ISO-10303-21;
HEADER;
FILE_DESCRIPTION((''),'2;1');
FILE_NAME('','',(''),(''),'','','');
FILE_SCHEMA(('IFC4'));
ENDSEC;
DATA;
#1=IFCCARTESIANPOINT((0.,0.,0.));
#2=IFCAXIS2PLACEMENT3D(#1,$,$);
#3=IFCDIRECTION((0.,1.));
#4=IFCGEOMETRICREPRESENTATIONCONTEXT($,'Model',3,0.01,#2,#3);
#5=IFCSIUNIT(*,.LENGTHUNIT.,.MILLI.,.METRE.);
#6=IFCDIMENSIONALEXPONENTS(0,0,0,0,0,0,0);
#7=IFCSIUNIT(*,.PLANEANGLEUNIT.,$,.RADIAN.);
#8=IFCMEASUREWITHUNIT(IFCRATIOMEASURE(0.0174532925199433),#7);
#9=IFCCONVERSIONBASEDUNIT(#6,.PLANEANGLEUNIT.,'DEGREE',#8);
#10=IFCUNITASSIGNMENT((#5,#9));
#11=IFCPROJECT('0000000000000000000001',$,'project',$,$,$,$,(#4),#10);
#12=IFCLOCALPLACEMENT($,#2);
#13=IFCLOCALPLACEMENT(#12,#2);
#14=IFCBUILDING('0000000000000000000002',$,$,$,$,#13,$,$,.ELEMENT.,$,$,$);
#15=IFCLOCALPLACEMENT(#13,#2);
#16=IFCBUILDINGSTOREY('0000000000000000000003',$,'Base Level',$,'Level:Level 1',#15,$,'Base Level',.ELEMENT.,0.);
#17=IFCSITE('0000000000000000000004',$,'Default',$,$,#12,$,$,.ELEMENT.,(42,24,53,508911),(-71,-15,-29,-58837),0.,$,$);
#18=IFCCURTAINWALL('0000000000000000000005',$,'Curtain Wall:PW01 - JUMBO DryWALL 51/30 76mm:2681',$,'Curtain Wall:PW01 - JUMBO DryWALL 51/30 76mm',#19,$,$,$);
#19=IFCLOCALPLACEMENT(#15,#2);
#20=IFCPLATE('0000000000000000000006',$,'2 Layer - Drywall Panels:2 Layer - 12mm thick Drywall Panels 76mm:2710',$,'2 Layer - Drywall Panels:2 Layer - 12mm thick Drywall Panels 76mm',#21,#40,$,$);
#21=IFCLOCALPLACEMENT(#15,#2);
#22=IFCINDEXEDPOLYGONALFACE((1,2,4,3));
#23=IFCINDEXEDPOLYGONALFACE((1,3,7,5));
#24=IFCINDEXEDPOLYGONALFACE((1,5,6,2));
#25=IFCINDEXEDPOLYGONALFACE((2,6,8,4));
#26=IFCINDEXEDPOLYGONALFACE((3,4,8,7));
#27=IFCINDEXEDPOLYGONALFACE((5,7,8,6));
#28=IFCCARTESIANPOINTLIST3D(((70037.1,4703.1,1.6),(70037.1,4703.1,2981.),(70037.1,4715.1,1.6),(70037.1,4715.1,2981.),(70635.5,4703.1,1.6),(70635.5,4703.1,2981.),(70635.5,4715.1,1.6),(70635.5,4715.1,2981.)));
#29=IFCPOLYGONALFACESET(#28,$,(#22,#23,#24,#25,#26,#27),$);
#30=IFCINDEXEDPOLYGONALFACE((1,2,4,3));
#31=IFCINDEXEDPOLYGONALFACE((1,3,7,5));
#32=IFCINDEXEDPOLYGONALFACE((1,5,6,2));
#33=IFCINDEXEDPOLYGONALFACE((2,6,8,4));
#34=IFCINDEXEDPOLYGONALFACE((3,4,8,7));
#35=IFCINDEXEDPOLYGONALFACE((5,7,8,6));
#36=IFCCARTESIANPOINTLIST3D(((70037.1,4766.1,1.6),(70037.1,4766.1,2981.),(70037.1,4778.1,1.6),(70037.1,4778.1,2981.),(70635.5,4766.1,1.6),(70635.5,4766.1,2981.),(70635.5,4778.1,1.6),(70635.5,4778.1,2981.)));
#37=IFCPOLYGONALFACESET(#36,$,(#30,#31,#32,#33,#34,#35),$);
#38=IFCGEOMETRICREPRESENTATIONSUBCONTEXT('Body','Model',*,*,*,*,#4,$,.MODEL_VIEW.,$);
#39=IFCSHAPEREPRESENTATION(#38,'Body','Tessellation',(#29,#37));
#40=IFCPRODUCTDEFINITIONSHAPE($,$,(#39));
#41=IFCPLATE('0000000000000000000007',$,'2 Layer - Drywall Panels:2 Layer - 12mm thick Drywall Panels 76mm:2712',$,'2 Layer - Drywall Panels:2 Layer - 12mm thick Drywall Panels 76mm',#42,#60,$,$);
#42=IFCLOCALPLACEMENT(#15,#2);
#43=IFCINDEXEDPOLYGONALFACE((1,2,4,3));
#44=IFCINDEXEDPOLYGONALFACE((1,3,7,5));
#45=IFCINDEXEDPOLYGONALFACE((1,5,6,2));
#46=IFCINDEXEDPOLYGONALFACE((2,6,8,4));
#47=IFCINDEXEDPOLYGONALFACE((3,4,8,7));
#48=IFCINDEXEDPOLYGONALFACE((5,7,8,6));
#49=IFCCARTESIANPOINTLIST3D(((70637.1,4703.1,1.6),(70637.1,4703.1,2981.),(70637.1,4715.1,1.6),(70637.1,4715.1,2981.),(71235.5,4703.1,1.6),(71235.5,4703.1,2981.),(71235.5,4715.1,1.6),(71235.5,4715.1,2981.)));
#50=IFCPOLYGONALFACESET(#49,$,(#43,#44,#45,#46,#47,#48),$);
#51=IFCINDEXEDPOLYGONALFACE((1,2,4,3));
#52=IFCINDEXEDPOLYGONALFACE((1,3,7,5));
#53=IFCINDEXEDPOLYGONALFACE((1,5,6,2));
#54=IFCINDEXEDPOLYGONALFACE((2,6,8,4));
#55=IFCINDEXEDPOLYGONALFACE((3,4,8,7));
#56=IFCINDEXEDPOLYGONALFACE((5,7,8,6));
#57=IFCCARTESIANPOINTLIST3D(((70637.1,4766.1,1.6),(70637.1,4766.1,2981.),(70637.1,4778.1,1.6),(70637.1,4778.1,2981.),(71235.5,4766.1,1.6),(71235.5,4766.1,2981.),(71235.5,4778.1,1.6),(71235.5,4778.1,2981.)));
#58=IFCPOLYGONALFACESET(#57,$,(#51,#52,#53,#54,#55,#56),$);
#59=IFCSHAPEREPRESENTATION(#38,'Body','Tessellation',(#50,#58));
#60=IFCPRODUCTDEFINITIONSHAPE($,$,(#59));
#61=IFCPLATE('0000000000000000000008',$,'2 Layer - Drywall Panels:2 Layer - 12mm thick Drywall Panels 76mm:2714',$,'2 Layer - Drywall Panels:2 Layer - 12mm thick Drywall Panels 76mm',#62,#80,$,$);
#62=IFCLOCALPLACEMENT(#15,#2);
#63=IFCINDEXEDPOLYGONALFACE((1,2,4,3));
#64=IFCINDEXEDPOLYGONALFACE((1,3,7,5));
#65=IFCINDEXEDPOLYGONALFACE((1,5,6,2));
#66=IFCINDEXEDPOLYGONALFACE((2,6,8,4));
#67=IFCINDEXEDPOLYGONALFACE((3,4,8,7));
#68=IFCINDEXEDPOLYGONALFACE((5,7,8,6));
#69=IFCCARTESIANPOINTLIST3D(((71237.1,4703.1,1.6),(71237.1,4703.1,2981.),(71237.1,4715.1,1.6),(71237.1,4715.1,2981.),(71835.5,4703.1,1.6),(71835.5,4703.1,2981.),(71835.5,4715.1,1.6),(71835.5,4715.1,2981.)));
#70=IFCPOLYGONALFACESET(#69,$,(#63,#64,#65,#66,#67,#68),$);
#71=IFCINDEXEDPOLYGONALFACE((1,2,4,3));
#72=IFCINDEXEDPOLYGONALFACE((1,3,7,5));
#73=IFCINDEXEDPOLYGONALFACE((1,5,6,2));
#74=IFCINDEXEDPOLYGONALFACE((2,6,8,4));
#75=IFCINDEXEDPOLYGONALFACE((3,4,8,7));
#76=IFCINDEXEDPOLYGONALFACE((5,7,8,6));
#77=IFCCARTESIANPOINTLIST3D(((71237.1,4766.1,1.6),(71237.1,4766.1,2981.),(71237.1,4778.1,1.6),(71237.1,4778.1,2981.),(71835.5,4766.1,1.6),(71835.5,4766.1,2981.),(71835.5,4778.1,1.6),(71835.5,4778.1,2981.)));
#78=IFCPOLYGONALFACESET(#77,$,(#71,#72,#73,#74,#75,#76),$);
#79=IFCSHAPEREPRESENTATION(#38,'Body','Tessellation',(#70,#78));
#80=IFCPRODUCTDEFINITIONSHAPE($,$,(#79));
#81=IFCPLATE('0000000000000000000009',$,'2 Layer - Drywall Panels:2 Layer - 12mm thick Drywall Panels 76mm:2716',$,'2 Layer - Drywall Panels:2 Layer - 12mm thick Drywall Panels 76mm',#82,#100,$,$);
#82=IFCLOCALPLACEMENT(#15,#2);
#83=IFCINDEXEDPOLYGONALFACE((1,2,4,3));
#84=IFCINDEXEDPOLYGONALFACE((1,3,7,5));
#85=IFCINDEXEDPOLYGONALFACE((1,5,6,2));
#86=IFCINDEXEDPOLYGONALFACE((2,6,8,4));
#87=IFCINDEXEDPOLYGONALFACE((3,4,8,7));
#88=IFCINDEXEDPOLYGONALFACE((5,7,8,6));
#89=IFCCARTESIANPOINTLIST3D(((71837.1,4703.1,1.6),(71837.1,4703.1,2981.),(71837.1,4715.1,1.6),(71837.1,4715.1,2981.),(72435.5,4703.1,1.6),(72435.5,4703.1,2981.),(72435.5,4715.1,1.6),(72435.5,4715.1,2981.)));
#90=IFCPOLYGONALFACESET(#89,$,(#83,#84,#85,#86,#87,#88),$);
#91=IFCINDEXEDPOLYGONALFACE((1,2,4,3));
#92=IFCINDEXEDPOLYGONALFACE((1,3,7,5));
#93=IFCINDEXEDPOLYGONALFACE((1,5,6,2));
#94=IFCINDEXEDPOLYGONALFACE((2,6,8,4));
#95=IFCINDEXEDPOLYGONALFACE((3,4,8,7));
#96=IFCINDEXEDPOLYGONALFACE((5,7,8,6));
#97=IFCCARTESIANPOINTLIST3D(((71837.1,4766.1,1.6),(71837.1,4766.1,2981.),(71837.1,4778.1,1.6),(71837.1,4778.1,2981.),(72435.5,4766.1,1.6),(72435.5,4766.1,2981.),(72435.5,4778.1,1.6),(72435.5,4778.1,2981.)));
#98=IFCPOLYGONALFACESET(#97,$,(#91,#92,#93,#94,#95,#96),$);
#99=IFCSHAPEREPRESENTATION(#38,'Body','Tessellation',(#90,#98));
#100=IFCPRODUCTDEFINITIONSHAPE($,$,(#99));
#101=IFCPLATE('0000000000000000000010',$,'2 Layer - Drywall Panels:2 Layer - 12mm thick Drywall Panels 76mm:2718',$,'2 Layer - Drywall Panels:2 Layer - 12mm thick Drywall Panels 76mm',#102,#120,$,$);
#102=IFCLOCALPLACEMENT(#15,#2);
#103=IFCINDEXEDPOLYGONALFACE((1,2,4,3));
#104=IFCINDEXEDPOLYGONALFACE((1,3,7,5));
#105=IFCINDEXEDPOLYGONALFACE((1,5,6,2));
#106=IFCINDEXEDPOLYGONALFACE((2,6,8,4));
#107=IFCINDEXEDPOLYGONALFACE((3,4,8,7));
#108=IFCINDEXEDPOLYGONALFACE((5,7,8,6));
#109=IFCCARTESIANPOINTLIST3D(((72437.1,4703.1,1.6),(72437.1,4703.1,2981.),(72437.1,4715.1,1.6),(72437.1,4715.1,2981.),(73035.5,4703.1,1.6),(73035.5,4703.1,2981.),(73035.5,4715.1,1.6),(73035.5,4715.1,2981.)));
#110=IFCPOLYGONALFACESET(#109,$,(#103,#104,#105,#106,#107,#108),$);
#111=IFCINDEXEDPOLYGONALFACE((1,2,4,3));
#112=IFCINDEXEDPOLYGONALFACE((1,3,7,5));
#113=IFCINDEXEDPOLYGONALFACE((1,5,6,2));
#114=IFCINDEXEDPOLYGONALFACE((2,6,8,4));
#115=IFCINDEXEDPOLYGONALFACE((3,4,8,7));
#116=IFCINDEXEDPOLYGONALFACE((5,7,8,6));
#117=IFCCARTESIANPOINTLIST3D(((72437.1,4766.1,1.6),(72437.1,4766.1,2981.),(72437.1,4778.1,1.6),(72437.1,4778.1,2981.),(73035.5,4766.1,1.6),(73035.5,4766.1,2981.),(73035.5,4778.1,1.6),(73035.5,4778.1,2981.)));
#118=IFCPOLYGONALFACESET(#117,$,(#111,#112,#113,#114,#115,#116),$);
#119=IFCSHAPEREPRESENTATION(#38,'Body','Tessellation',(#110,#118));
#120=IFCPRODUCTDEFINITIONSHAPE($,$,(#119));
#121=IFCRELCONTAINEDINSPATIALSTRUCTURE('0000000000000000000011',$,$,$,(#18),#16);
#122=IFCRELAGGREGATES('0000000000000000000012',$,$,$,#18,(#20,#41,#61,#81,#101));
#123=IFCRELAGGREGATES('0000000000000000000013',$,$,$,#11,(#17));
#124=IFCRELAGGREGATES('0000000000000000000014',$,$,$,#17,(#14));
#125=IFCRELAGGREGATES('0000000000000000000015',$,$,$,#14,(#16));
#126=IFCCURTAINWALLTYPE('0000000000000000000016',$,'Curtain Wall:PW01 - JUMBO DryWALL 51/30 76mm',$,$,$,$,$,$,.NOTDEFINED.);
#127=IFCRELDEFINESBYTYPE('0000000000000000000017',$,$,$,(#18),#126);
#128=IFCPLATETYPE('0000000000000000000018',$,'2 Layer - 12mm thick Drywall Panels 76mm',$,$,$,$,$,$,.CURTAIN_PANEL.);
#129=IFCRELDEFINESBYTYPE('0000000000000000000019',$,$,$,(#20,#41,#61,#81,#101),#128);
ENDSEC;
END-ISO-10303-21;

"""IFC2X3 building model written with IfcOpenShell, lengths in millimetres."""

from ifc_helpers import new_model, entity, si_unit, converted_unit, direction, frame, frame_2d, origin, origin_2d_with_axis, place, context, subcontext, project, spatial, rectangle, extrude, source, transform, mapped, type_object, type_shapes, element, aggregate, save


model = new_model("IFC2X3")

# Units and contexts
model_context = context("Model", 3, precision=0.01, world=origin(), true_north=direction((0.0, 1.0)))
body_context = subcontext(model_context, "Body", "Model", "MODEL_VIEW")
ifc_project = project(units=[si_unit("LENGTHUNIT", "METRE", prefix="MILLI"), converted_unit("PLANEANGLEUNIT", "DEGREE", entity("IfcRatioMeasure", 0.0174532925199433), si_unit("PLANEANGLEUNIT", "RADIAN"), dimensions=[0, 0, 0, 0, 0, 0, 0])], contexts=[model_context])

# Site, building, storey
site_placement = place(None, origin())
site = spatial("IfcSite", under=ifc_project, at=site_placement, Name="Default", CompositionType="ELEMENT", RefLatitude=(42, 24, 53, 508911), RefLongitude=(-71, -15, -29, -58837), RefElevation=0.0)
building_placement = place(site_placement, origin())
building = spatial("IfcBuilding", under=site, at=building_placement, CompositionType="ELEMENT")
storey_placement = place(building_placement, origin())
storey = spatial("IfcBuildingStorey", under=building, at=storey_placement, Name="Base Level", ObjectType="Level:Level 1", LongName="Base Level", CompositionType="ELEMENT", Elevation=0.0)

# Curtain wall, plates
curtain_wall_type = type_object("IfcCurtainWallType", Name="Curtain Wall:PW01 - JUMBO DryWALL 51/30 76mm", PredefinedType="NOTDEFINED")
curtain_wall_placement = place(building_placement, origin())
curtain_wall = element("IfcCurtainWall", 1, at=curtain_wall_placement, inside=storey, type_object=curtain_wall_type, Name="Curtain Wall:PW01 - JUMBO DryWALL 51/30 76mm:2681", ObjectType="Curtain Wall:PW01 - JUMBO DryWALL 51/30 76mm")
plate_type = type_object("IfcPlateType", Name="2 Layer - 12mm thick Drywall Panels 76mm", PredefinedType="CURTAIN_PANEL")
shared_shape_1 = source(origin(), body_context, "Body", "SweptSolid", [
    extrude(rectangle(XDim=598.4, YDim=12.0, at=origin_2d_with_axis()), frame((0.0, -31.5, 0.0), z_axis=(0.0, 0.0, 1.0), x_axis=(-1.0, 0.0, 0.0)), (0.0, 0.0, 1.0), 2979.4),
    extrude(rectangle(XDim=12.0, YDim=598.4, at=frame_2d((0.0, 0.0), x_axis=(1.0, 0.0))), frame((0.0, 31.5, 0.0), z_axis=(0.0, 0.0, 1.0), x_axis=(0.0, 1.0, 0.0)), (0.0, 0.0, 1.0), 2979.4),
])
type_shapes(plate_type, [shared_shape_1])
plate_1_placement = place(curtain_wall_placement, frame((70336.3, 4740.6, 1.6)))
plate_1 = element("IfcPlate", 2, at=plate_1_placement, type_object=plate_type, Name="2 Layer - Drywall Panels:2 Layer - 12mm thick Drywall Panels 76mm:2710", ObjectType="2 Layer - Drywall Panels:2 Layer - 12mm thick Drywall Panels 76mm", context=body_context, shape_type="MappedRepresentation", body=[
    mapped(shared_shape_1, transform((0.0, 0.0, 0.0), scale=1.0)),
])
plate_2_placement = place(curtain_wall_placement, frame((70936.3, 4740.6, 1.6)))
plate_2 = element("IfcPlate", 3, at=plate_2_placement, type_object=plate_type, Name="2 Layer - Drywall Panels:2 Layer - 12mm thick Drywall Panels 76mm:2712", ObjectType="2 Layer - Drywall Panels:2 Layer - 12mm thick Drywall Panels 76mm", context=body_context, shape_type="MappedRepresentation", body=[
    mapped(shared_shape_1, transform((0.0, 0.0, 0.0), scale=1.0)),
])
plate_3_placement = place(curtain_wall_placement, frame((71536.3, 4740.6, 1.6)))
plate_3 = element("IfcPlate", 4, at=plate_3_placement, type_object=plate_type, Name="2 Layer - Drywall Panels:2 Layer - 12mm thick Drywall Panels 76mm:2714", ObjectType="2 Layer - Drywall Panels:2 Layer - 12mm thick Drywall Panels 76mm", context=body_context, shape_type="MappedRepresentation", body=[
    mapped(shared_shape_1, transform((0.0, 0.0, 0.0), scale=1.0)),
])
plate_4_placement = place(curtain_wall_placement, frame((72136.3, 4740.6, 1.6)))
plate_4 = element("IfcPlate", 5, at=plate_4_placement, type_object=plate_type, Name="2 Layer - Drywall Panels:2 Layer - 12mm thick Drywall Panels 76mm:2716", ObjectType="2 Layer - Drywall Panels:2 Layer - 12mm thick Drywall Panels 76mm", context=body_context, shape_type="MappedRepresentation", body=[
    mapped(shared_shape_1, transform((0.0, 0.0, 0.0), scale=1.0)),
])
plate_5_placement = place(curtain_wall_placement, frame((72736.3, 4740.6, 1.6)))
plate_5 = element("IfcPlate", 6, at=plate_5_placement, type_object=plate_type, Name="2 Layer - Drywall Panels:2 Layer - 12mm thick Drywall Panels 76mm:2718", ObjectType="2 Layer - Drywall Panels:2 Layer - 12mm thick Drywall Panels 76mm", context=body_context, shape_type="MappedRepresentation", body=[
    mapped(shared_shape_1, transform((0.0, 0.0, 0.0), scale=1.0)),
])
aggregate(curtain_wall, [plate_1, plate_2, plate_3, plate_4, plate_5])

save(model, "model.ifc")
